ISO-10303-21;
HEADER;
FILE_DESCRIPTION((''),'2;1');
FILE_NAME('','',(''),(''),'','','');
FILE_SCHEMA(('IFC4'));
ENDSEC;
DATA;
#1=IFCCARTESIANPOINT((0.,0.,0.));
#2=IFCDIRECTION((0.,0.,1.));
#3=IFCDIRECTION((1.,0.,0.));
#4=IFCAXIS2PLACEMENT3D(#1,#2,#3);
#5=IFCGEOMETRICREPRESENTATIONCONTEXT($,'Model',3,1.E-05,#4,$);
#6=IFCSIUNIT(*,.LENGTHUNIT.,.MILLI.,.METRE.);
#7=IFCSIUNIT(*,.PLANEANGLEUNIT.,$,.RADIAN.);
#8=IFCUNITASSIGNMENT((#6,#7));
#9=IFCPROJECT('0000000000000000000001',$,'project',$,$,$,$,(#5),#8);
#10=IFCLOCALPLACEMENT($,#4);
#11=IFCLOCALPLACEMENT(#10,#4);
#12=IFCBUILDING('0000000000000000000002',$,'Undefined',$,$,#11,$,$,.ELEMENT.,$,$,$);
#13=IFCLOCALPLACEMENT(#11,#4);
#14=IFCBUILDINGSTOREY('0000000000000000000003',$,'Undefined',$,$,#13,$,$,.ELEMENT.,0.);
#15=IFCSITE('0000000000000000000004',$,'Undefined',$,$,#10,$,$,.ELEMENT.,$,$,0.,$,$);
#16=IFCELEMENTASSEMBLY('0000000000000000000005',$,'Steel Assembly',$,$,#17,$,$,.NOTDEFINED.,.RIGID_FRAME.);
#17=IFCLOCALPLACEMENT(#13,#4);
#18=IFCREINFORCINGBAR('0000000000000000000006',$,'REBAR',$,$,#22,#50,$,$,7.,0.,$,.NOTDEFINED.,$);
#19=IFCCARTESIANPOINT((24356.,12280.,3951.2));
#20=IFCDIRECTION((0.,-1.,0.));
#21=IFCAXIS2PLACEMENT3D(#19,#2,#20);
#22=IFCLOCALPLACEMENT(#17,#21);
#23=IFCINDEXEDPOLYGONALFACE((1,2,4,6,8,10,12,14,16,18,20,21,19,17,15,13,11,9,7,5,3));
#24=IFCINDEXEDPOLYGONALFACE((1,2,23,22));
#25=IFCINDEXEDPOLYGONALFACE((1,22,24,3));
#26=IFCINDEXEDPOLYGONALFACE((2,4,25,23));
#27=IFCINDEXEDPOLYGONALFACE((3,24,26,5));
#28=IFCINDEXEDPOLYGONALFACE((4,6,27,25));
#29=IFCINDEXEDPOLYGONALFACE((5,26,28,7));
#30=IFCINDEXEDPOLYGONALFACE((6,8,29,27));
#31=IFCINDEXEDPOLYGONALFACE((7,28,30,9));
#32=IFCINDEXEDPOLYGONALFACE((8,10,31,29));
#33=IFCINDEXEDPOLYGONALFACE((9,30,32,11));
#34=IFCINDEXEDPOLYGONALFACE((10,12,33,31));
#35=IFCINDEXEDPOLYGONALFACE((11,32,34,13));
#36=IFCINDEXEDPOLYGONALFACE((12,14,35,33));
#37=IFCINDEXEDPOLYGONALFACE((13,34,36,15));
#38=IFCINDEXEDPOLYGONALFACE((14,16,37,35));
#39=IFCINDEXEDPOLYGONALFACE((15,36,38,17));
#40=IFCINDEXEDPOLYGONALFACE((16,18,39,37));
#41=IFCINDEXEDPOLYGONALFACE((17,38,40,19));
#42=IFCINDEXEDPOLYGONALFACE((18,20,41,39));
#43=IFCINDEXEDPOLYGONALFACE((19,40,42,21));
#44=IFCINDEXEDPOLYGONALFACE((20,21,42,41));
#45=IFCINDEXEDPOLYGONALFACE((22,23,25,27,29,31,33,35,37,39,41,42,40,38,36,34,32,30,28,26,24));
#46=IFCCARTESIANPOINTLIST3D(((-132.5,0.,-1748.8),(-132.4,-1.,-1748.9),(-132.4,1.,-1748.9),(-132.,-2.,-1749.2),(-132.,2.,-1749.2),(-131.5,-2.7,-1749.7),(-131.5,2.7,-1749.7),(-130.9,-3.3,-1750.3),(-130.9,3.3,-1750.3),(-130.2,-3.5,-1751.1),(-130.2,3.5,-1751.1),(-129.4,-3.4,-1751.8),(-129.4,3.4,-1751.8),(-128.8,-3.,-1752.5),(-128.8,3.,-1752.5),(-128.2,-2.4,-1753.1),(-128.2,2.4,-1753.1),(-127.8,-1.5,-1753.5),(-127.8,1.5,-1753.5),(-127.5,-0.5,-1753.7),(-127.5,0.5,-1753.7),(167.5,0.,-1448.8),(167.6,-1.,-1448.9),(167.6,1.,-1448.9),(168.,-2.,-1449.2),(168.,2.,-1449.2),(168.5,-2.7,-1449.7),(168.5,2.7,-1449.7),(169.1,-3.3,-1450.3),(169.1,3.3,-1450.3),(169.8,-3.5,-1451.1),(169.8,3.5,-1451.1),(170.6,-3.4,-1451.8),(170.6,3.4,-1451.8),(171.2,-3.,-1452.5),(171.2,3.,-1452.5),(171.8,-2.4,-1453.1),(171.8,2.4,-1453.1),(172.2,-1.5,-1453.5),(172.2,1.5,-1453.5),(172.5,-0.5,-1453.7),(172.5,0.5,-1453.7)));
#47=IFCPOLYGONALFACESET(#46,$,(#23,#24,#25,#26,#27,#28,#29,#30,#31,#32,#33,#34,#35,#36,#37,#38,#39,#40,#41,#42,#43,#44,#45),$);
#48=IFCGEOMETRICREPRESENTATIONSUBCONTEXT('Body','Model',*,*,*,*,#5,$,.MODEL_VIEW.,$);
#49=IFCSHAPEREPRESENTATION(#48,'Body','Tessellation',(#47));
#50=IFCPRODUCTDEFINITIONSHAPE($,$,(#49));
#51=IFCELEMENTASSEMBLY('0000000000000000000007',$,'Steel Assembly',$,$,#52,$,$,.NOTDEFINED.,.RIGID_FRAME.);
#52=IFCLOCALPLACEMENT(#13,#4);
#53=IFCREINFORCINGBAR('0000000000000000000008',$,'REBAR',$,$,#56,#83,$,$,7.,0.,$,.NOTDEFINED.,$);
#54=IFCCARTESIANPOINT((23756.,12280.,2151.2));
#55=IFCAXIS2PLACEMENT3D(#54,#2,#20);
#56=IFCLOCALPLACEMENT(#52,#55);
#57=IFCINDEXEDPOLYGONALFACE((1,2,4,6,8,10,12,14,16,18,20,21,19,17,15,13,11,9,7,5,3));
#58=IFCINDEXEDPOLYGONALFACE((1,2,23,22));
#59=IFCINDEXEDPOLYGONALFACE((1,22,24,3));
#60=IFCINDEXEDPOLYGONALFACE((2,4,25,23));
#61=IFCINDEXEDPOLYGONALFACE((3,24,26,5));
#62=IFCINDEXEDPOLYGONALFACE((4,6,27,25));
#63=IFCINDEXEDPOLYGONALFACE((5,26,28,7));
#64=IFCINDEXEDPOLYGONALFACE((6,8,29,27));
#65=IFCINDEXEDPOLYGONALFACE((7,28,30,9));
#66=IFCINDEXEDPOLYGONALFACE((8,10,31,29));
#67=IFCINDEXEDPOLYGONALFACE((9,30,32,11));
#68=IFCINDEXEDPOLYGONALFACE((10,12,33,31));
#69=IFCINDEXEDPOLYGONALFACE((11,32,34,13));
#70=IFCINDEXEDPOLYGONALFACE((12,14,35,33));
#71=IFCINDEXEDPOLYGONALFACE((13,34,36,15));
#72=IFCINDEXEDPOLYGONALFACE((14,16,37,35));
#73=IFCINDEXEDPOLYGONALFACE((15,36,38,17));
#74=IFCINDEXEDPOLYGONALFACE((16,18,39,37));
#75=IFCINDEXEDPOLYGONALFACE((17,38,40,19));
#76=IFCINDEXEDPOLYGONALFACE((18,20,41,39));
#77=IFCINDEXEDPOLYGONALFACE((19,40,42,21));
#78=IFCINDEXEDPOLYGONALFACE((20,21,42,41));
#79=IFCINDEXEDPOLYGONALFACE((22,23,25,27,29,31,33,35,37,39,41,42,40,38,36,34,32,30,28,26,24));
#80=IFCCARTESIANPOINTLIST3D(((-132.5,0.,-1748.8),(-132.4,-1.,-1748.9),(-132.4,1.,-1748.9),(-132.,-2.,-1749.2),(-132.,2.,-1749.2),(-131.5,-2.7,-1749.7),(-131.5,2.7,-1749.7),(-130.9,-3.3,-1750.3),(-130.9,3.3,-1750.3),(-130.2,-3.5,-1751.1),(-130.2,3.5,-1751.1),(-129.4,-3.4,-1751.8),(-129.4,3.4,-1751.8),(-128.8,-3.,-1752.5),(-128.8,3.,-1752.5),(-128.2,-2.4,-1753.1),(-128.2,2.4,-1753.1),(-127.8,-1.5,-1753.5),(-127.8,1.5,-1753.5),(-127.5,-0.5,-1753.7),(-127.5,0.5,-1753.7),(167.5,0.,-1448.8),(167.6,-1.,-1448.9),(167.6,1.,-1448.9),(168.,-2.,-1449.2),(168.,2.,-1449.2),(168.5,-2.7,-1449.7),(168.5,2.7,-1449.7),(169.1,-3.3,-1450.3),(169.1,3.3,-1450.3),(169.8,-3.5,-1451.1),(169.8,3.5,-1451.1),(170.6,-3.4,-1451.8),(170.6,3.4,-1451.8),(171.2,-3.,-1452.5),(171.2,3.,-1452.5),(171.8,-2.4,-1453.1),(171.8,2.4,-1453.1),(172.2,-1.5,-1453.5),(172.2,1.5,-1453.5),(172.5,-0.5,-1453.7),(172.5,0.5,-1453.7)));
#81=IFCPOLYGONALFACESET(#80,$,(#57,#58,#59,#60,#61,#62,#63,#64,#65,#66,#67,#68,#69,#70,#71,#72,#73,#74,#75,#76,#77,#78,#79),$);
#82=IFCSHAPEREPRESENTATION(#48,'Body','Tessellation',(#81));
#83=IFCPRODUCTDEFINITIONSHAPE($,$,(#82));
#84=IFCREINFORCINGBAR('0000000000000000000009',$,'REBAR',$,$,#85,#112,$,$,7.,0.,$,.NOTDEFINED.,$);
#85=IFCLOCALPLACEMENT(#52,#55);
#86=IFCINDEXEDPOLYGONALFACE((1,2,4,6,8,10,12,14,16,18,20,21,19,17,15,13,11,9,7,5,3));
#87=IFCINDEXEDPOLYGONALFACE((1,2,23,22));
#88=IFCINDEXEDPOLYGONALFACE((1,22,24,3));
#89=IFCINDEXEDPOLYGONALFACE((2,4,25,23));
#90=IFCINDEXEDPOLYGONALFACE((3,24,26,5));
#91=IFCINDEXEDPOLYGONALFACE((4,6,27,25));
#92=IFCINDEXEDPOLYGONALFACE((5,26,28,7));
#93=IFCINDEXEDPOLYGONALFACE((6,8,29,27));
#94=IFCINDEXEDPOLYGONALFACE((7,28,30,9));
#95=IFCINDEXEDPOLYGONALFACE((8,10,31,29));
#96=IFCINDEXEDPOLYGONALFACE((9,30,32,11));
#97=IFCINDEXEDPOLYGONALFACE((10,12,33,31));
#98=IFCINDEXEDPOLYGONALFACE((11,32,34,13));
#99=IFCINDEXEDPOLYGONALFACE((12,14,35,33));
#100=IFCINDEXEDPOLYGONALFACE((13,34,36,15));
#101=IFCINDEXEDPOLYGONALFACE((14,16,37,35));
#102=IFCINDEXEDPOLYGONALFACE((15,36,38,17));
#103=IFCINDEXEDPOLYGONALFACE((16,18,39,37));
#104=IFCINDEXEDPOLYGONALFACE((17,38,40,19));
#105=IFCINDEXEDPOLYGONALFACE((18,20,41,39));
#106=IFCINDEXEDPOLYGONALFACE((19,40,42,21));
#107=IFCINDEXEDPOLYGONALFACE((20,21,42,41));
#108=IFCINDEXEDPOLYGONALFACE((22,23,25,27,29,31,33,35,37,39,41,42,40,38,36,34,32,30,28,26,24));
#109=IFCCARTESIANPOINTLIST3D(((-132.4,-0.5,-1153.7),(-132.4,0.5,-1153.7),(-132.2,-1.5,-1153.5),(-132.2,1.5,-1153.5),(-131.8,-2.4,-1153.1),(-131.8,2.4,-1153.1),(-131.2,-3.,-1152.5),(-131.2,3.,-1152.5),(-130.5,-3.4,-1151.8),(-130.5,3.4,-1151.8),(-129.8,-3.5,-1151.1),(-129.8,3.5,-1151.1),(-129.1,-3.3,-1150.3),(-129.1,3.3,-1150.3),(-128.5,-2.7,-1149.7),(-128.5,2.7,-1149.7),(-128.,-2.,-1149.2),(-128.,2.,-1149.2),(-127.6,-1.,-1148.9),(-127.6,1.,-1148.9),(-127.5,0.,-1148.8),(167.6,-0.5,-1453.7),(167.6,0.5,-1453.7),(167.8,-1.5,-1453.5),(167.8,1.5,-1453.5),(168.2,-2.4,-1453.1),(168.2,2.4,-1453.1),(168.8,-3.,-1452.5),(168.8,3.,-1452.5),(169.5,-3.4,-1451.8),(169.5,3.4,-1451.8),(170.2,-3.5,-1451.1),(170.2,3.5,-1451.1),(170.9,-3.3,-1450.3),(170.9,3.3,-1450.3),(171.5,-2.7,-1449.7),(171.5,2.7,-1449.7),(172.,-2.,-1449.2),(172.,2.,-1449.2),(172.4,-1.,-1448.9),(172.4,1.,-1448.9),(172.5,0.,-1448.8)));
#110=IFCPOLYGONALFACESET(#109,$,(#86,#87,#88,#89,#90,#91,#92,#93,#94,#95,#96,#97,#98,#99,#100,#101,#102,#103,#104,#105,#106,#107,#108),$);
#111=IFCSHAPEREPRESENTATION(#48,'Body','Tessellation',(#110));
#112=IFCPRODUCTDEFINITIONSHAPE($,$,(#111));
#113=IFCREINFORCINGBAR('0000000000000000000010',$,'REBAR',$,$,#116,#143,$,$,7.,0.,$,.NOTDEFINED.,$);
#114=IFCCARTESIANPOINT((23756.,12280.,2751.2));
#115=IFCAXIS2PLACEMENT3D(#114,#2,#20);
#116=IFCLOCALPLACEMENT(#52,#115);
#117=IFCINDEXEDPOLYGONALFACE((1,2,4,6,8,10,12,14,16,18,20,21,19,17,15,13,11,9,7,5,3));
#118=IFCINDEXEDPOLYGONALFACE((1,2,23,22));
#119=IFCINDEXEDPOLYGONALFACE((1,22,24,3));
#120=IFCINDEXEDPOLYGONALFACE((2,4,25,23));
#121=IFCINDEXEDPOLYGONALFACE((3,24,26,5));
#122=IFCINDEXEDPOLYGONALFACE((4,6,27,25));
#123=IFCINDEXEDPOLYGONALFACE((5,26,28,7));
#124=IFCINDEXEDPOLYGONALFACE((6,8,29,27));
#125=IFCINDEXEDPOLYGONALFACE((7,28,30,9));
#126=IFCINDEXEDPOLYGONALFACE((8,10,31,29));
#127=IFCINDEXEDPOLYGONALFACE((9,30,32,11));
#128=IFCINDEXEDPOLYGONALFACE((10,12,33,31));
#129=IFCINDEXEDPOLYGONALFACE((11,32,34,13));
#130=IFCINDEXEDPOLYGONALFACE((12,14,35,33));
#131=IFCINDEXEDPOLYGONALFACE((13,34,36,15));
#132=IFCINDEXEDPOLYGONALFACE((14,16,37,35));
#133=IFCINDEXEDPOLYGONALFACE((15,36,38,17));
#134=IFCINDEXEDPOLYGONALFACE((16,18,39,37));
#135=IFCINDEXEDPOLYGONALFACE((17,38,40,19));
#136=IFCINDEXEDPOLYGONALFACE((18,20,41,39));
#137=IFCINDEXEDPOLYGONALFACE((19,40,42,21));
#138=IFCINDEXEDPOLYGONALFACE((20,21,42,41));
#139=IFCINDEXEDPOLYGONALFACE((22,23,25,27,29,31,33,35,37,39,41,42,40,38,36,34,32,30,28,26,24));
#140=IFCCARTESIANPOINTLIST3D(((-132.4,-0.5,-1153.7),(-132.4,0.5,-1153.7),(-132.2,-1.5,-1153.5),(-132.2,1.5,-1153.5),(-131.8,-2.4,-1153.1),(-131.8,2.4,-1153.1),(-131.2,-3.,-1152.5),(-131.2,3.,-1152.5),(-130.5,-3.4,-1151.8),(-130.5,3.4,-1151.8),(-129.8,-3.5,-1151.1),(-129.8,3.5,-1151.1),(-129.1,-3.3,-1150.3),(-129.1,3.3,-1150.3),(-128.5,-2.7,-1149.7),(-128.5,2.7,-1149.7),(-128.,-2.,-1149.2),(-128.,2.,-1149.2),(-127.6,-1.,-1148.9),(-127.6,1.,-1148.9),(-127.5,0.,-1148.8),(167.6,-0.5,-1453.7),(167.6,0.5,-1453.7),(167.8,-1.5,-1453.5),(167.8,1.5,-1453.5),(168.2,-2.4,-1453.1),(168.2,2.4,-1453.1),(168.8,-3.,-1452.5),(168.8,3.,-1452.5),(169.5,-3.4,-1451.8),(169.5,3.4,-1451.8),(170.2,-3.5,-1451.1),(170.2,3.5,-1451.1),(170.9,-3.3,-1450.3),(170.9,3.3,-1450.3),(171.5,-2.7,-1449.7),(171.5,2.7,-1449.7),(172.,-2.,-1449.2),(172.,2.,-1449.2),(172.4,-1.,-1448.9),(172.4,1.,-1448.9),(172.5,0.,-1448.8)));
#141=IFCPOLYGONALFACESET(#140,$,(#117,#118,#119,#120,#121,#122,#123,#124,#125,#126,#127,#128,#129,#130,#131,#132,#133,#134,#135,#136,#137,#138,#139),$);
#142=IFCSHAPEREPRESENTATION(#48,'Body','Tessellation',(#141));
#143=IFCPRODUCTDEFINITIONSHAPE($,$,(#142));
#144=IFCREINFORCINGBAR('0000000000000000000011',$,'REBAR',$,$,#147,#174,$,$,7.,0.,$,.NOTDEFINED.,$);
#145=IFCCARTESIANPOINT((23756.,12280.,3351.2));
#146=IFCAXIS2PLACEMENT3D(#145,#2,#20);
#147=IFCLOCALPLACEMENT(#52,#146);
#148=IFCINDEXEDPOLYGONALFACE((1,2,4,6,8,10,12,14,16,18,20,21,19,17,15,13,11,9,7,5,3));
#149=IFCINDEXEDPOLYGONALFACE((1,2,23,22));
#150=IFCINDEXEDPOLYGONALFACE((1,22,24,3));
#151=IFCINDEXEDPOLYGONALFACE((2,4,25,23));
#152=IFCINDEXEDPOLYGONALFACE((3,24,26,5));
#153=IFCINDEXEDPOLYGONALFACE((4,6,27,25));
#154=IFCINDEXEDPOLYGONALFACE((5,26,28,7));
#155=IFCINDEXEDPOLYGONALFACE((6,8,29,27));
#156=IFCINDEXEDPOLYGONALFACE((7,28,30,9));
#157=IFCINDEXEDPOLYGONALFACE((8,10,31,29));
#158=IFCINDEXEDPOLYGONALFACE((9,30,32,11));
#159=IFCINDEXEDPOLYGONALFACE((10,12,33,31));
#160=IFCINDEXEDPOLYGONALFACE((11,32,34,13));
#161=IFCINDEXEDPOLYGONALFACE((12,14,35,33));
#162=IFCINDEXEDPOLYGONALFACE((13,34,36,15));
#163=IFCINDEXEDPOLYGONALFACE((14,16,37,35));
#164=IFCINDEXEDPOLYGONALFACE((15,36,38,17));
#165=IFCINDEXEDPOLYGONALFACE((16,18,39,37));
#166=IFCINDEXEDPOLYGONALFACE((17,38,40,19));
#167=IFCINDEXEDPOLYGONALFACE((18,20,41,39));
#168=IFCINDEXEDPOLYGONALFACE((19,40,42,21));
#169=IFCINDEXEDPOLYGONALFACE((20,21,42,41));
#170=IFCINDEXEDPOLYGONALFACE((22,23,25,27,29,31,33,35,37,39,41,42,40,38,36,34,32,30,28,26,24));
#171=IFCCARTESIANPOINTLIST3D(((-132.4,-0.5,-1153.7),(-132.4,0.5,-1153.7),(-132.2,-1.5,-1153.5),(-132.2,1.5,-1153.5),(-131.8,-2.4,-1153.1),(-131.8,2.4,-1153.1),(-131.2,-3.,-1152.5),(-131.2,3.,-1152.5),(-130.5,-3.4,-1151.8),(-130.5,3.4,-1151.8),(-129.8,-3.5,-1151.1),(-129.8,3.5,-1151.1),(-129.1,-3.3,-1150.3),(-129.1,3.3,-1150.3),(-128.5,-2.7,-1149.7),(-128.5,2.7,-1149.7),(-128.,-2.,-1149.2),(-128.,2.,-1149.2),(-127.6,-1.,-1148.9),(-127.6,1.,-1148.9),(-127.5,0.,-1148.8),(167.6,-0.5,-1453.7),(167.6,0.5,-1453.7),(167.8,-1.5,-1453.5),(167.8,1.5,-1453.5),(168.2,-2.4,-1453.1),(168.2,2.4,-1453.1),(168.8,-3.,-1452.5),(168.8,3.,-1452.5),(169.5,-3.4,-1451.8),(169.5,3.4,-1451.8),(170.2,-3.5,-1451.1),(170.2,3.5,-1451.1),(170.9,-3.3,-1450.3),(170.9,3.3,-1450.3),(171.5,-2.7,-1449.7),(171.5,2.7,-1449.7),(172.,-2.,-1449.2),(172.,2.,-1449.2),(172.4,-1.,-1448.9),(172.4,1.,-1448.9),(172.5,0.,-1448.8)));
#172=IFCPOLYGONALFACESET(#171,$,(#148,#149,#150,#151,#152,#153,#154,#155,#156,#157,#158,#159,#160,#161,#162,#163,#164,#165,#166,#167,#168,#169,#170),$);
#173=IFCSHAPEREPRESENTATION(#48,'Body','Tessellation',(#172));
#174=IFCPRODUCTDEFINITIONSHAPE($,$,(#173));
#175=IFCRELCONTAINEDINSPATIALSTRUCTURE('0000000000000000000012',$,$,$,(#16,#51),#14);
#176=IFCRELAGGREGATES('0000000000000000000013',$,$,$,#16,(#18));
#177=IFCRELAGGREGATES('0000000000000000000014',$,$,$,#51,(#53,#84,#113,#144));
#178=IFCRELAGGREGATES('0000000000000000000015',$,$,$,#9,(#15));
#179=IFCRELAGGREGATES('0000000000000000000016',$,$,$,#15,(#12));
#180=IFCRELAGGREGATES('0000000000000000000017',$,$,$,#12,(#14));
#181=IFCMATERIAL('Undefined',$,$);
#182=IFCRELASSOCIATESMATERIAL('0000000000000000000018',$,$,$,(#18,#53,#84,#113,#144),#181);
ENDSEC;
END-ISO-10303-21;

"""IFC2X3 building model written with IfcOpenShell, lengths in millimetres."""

from ifc_helpers import new_model, entity, si_unit, frame, origin_with_axes, place, context, subcontext, project, spatial, source, transform, mapped, material, element, aggregate, save


model = new_model("IFC2X3")

# Units and contexts
model_context = context("Model", 3, precision=1e-05, world=origin_with_axes())
body_context = subcontext(model_context, "Body", "Model", "MODEL_VIEW")
ifc_project = project(units=[si_unit("LENGTHUNIT", "METRE", prefix="MILLI"), si_unit("PLANEANGLEUNIT", "RADIAN")], contexts=[model_context])

# Site, building, storey
site_placement = place(None, origin_with_axes())
site = spatial("IfcSite", under=ifc_project, at=site_placement, Name="Undefined", CompositionType="ELEMENT", RefElevation=0.0)
building_placement = place(site_placement, origin_with_axes())
building = spatial("IfcBuilding", under=site, at=building_placement, Name="Undefined", CompositionType="ELEMENT")
storey_placement = place(building_placement, origin_with_axes())
storey = spatial("IfcBuildingStorey", under=building, at=storey_placement, Name="Undefined", CompositionType="ELEMENT", Elevation=0.0)

# Shared definitions
ifc_material_1 = material(Name="Undefined")

# Element assemblies, reinforcing bars
assembly_1_placement = place(storey_placement, origin_with_axes())
assembly_1 = element("IfcElementAssembly", 1, at=assembly_1_placement, inside=storey, Name="Steel Assembly", AssemblyPlace="NOTDEFINED", PredefinedType="RIGID_FRAME")
shared_shape_1 = source(origin_with_axes(), body_context, "Body", "AdvancedSweptSolid", [
    entity("IfcSweptDiskSolid", entity("IfcTrimmedCurve", entity("IfcLine", entity("IfcCartesianPoint", [0.0, 0.0, 0.0]), entity("IfcVector", entity("IfcDirection", [0.707107, 0.0, 0.707107]), 1.0)), [entity("IfcParameterValue", 0.0)], [entity("IfcParameterValue", 424.264069)], True, "PARAMETER"), 3.5, None, 0.0, 424.3),
])
reinforcing_bar_1_placement = place(assembly_1_placement, frame((24356.0, 12280.0, 3951.2), z_axis=(0.0, 0.0, 1.0), x_axis=(0.0, -1.0, 0.0)))
reinforcing_bar_1 = element("IfcReinforcingBar", 2, at=reinforcing_bar_1_placement, material=ifc_material_1, Name="REBAR", BarRole="NOTDEFINED", CrossSectionArea=0.0, NominalDiameter=7.0, context=body_context, shape_type="MappedRepresentation", body=[
    mapped(shared_shape_1, transform((-130.0, 0.0, -1751.2))),
])
aggregate(assembly_1, [reinforcing_bar_1])
assembly_2_placement = place(storey_placement, origin_with_axes())
assembly_2 = element("IfcElementAssembly", 3, at=assembly_2_placement, inside=storey, Name="Steel Assembly", AssemblyPlace="NOTDEFINED", PredefinedType="RIGID_FRAME")
shared_shape_2 = source(origin_with_axes(), body_context, "Body", "AdvancedSweptSolid", [
    entity("IfcSweptDiskSolid", entity("IfcTrimmedCurve", entity("IfcLine", entity("IfcCartesianPoint", [0.0, 0.0, 0.0]), entity("IfcVector", entity("IfcDirection", [0.707107, 0.0, 0.707107]), 1.0)), [entity("IfcParameterValue", 0.0)], [entity("IfcParameterValue", 424.264069)], True, "PARAMETER"), 3.5, None, 0.0, 424.3),
])
reinforcing_bar_2_placement = place(assembly_2_placement, frame((23756.0, 12280.0, 2151.2), z_axis=(0.0, 0.0, 1.0), x_axis=(0.0, -1.0, 0.0)))
reinforcing_bar_2 = element("IfcReinforcingBar", 4, at=reinforcing_bar_2_placement, material=ifc_material_1, Name="REBAR", BarRole="NOTDEFINED", CrossSectionArea=0.0, NominalDiameter=7.0, context=body_context, shape_type="MappedRepresentation", body=[
    mapped(shared_shape_2, transform((-130.0, 0.0, -1751.2))),
])
shared_shape_3 = source(origin_with_axes(), body_context, "Body", "AdvancedSweptSolid", [
    entity("IfcSweptDiskSolid", entity("IfcTrimmedCurve", entity("IfcLine", entity("IfcCartesianPoint", [0.0, 0.0, 0.0]), entity("IfcVector", entity("IfcDirection", [0.707107, 0.0, -0.707107]), 1.0)), [entity("IfcParameterValue", 0.0)], [entity("IfcParameterValue", 424.264069)], True, "PARAMETER"), 3.5, None, 0.0, 424.3),
])
reinforcing_bar_3_placement = place(assembly_2_placement, frame((23756.0, 12280.0, 2151.2), z_axis=(0.0, 0.0, 1.0), x_axis=(0.0, -1.0, 0.0)))
reinforcing_bar_3 = element("IfcReinforcingBar", 5, at=reinforcing_bar_3_placement, material=ifc_material_1, Name="REBAR", BarRole="NOTDEFINED", CrossSectionArea=0.0, NominalDiameter=7.0, context=body_context, shape_type="MappedRepresentation", body=[
    mapped(shared_shape_3, transform((-130.0, 0.0, -1151.2))),
])
shared_shape_4 = source(origin_with_axes(), body_context, "Body", "AdvancedSweptSolid", [
    entity("IfcSweptDiskSolid", entity("IfcTrimmedCurve", entity("IfcLine", entity("IfcCartesianPoint", [0.0, 0.0, 0.0]), entity("IfcVector", entity("IfcDirection", [0.707107, 0.0, -0.707107]), 1.0)), [entity("IfcParameterValue", 0.0)], [entity("IfcParameterValue", 424.264069)], True, "PARAMETER"), 3.5, None, 0.0, 424.3),
])
reinforcing_bar_4_placement = place(assembly_2_placement, frame((23756.0, 12280.0, 2751.2), z_axis=(0.0, 0.0, 1.0), x_axis=(0.0, -1.0, 0.0)))
reinforcing_bar_4 = element("IfcReinforcingBar", 6, at=reinforcing_bar_4_placement, material=ifc_material_1, Name="REBAR", BarRole="NOTDEFINED", CrossSectionArea=0.0, NominalDiameter=7.0, context=body_context, shape_type="MappedRepresentation", body=[
    mapped(shared_shape_4, transform((-130.0, 0.0, -1151.2))),
])
shared_shape_5 = source(origin_with_axes(), body_context, "Body", "AdvancedSweptSolid", [
    entity("IfcSweptDiskSolid", entity("IfcTrimmedCurve", entity("IfcLine", entity("IfcCartesianPoint", [0.0, 0.0, 0.0]), entity("IfcVector", entity("IfcDirection", [0.707107, 0.0, -0.707107]), 1.0)), [entity("IfcParameterValue", 0.0)], [entity("IfcParameterValue", 424.264069)], True, "PARAMETER"), 3.5, None, 0.0, 424.3),
])
reinforcing_bar_5_placement = place(assembly_2_placement, frame((23756.0, 12280.0, 3351.2), z_axis=(0.0, 0.0, 1.0), x_axis=(0.0, -1.0, 0.0)))
reinforcing_bar_5 = element("IfcReinforcingBar", 7, at=reinforcing_bar_5_placement, material=ifc_material_1, Name="REBAR", BarRole="NOTDEFINED", CrossSectionArea=0.0, NominalDiameter=7.0, context=body_context, shape_type="MappedRepresentation", body=[
    mapped(shared_shape_5, transform((-130.0, 0.0, -1151.2))),
])
aggregate(assembly_2, [reinforcing_bar_2, reinforcing_bar_3, reinforcing_bar_4, reinforcing_bar_5])

save(model, "model.ifc")
